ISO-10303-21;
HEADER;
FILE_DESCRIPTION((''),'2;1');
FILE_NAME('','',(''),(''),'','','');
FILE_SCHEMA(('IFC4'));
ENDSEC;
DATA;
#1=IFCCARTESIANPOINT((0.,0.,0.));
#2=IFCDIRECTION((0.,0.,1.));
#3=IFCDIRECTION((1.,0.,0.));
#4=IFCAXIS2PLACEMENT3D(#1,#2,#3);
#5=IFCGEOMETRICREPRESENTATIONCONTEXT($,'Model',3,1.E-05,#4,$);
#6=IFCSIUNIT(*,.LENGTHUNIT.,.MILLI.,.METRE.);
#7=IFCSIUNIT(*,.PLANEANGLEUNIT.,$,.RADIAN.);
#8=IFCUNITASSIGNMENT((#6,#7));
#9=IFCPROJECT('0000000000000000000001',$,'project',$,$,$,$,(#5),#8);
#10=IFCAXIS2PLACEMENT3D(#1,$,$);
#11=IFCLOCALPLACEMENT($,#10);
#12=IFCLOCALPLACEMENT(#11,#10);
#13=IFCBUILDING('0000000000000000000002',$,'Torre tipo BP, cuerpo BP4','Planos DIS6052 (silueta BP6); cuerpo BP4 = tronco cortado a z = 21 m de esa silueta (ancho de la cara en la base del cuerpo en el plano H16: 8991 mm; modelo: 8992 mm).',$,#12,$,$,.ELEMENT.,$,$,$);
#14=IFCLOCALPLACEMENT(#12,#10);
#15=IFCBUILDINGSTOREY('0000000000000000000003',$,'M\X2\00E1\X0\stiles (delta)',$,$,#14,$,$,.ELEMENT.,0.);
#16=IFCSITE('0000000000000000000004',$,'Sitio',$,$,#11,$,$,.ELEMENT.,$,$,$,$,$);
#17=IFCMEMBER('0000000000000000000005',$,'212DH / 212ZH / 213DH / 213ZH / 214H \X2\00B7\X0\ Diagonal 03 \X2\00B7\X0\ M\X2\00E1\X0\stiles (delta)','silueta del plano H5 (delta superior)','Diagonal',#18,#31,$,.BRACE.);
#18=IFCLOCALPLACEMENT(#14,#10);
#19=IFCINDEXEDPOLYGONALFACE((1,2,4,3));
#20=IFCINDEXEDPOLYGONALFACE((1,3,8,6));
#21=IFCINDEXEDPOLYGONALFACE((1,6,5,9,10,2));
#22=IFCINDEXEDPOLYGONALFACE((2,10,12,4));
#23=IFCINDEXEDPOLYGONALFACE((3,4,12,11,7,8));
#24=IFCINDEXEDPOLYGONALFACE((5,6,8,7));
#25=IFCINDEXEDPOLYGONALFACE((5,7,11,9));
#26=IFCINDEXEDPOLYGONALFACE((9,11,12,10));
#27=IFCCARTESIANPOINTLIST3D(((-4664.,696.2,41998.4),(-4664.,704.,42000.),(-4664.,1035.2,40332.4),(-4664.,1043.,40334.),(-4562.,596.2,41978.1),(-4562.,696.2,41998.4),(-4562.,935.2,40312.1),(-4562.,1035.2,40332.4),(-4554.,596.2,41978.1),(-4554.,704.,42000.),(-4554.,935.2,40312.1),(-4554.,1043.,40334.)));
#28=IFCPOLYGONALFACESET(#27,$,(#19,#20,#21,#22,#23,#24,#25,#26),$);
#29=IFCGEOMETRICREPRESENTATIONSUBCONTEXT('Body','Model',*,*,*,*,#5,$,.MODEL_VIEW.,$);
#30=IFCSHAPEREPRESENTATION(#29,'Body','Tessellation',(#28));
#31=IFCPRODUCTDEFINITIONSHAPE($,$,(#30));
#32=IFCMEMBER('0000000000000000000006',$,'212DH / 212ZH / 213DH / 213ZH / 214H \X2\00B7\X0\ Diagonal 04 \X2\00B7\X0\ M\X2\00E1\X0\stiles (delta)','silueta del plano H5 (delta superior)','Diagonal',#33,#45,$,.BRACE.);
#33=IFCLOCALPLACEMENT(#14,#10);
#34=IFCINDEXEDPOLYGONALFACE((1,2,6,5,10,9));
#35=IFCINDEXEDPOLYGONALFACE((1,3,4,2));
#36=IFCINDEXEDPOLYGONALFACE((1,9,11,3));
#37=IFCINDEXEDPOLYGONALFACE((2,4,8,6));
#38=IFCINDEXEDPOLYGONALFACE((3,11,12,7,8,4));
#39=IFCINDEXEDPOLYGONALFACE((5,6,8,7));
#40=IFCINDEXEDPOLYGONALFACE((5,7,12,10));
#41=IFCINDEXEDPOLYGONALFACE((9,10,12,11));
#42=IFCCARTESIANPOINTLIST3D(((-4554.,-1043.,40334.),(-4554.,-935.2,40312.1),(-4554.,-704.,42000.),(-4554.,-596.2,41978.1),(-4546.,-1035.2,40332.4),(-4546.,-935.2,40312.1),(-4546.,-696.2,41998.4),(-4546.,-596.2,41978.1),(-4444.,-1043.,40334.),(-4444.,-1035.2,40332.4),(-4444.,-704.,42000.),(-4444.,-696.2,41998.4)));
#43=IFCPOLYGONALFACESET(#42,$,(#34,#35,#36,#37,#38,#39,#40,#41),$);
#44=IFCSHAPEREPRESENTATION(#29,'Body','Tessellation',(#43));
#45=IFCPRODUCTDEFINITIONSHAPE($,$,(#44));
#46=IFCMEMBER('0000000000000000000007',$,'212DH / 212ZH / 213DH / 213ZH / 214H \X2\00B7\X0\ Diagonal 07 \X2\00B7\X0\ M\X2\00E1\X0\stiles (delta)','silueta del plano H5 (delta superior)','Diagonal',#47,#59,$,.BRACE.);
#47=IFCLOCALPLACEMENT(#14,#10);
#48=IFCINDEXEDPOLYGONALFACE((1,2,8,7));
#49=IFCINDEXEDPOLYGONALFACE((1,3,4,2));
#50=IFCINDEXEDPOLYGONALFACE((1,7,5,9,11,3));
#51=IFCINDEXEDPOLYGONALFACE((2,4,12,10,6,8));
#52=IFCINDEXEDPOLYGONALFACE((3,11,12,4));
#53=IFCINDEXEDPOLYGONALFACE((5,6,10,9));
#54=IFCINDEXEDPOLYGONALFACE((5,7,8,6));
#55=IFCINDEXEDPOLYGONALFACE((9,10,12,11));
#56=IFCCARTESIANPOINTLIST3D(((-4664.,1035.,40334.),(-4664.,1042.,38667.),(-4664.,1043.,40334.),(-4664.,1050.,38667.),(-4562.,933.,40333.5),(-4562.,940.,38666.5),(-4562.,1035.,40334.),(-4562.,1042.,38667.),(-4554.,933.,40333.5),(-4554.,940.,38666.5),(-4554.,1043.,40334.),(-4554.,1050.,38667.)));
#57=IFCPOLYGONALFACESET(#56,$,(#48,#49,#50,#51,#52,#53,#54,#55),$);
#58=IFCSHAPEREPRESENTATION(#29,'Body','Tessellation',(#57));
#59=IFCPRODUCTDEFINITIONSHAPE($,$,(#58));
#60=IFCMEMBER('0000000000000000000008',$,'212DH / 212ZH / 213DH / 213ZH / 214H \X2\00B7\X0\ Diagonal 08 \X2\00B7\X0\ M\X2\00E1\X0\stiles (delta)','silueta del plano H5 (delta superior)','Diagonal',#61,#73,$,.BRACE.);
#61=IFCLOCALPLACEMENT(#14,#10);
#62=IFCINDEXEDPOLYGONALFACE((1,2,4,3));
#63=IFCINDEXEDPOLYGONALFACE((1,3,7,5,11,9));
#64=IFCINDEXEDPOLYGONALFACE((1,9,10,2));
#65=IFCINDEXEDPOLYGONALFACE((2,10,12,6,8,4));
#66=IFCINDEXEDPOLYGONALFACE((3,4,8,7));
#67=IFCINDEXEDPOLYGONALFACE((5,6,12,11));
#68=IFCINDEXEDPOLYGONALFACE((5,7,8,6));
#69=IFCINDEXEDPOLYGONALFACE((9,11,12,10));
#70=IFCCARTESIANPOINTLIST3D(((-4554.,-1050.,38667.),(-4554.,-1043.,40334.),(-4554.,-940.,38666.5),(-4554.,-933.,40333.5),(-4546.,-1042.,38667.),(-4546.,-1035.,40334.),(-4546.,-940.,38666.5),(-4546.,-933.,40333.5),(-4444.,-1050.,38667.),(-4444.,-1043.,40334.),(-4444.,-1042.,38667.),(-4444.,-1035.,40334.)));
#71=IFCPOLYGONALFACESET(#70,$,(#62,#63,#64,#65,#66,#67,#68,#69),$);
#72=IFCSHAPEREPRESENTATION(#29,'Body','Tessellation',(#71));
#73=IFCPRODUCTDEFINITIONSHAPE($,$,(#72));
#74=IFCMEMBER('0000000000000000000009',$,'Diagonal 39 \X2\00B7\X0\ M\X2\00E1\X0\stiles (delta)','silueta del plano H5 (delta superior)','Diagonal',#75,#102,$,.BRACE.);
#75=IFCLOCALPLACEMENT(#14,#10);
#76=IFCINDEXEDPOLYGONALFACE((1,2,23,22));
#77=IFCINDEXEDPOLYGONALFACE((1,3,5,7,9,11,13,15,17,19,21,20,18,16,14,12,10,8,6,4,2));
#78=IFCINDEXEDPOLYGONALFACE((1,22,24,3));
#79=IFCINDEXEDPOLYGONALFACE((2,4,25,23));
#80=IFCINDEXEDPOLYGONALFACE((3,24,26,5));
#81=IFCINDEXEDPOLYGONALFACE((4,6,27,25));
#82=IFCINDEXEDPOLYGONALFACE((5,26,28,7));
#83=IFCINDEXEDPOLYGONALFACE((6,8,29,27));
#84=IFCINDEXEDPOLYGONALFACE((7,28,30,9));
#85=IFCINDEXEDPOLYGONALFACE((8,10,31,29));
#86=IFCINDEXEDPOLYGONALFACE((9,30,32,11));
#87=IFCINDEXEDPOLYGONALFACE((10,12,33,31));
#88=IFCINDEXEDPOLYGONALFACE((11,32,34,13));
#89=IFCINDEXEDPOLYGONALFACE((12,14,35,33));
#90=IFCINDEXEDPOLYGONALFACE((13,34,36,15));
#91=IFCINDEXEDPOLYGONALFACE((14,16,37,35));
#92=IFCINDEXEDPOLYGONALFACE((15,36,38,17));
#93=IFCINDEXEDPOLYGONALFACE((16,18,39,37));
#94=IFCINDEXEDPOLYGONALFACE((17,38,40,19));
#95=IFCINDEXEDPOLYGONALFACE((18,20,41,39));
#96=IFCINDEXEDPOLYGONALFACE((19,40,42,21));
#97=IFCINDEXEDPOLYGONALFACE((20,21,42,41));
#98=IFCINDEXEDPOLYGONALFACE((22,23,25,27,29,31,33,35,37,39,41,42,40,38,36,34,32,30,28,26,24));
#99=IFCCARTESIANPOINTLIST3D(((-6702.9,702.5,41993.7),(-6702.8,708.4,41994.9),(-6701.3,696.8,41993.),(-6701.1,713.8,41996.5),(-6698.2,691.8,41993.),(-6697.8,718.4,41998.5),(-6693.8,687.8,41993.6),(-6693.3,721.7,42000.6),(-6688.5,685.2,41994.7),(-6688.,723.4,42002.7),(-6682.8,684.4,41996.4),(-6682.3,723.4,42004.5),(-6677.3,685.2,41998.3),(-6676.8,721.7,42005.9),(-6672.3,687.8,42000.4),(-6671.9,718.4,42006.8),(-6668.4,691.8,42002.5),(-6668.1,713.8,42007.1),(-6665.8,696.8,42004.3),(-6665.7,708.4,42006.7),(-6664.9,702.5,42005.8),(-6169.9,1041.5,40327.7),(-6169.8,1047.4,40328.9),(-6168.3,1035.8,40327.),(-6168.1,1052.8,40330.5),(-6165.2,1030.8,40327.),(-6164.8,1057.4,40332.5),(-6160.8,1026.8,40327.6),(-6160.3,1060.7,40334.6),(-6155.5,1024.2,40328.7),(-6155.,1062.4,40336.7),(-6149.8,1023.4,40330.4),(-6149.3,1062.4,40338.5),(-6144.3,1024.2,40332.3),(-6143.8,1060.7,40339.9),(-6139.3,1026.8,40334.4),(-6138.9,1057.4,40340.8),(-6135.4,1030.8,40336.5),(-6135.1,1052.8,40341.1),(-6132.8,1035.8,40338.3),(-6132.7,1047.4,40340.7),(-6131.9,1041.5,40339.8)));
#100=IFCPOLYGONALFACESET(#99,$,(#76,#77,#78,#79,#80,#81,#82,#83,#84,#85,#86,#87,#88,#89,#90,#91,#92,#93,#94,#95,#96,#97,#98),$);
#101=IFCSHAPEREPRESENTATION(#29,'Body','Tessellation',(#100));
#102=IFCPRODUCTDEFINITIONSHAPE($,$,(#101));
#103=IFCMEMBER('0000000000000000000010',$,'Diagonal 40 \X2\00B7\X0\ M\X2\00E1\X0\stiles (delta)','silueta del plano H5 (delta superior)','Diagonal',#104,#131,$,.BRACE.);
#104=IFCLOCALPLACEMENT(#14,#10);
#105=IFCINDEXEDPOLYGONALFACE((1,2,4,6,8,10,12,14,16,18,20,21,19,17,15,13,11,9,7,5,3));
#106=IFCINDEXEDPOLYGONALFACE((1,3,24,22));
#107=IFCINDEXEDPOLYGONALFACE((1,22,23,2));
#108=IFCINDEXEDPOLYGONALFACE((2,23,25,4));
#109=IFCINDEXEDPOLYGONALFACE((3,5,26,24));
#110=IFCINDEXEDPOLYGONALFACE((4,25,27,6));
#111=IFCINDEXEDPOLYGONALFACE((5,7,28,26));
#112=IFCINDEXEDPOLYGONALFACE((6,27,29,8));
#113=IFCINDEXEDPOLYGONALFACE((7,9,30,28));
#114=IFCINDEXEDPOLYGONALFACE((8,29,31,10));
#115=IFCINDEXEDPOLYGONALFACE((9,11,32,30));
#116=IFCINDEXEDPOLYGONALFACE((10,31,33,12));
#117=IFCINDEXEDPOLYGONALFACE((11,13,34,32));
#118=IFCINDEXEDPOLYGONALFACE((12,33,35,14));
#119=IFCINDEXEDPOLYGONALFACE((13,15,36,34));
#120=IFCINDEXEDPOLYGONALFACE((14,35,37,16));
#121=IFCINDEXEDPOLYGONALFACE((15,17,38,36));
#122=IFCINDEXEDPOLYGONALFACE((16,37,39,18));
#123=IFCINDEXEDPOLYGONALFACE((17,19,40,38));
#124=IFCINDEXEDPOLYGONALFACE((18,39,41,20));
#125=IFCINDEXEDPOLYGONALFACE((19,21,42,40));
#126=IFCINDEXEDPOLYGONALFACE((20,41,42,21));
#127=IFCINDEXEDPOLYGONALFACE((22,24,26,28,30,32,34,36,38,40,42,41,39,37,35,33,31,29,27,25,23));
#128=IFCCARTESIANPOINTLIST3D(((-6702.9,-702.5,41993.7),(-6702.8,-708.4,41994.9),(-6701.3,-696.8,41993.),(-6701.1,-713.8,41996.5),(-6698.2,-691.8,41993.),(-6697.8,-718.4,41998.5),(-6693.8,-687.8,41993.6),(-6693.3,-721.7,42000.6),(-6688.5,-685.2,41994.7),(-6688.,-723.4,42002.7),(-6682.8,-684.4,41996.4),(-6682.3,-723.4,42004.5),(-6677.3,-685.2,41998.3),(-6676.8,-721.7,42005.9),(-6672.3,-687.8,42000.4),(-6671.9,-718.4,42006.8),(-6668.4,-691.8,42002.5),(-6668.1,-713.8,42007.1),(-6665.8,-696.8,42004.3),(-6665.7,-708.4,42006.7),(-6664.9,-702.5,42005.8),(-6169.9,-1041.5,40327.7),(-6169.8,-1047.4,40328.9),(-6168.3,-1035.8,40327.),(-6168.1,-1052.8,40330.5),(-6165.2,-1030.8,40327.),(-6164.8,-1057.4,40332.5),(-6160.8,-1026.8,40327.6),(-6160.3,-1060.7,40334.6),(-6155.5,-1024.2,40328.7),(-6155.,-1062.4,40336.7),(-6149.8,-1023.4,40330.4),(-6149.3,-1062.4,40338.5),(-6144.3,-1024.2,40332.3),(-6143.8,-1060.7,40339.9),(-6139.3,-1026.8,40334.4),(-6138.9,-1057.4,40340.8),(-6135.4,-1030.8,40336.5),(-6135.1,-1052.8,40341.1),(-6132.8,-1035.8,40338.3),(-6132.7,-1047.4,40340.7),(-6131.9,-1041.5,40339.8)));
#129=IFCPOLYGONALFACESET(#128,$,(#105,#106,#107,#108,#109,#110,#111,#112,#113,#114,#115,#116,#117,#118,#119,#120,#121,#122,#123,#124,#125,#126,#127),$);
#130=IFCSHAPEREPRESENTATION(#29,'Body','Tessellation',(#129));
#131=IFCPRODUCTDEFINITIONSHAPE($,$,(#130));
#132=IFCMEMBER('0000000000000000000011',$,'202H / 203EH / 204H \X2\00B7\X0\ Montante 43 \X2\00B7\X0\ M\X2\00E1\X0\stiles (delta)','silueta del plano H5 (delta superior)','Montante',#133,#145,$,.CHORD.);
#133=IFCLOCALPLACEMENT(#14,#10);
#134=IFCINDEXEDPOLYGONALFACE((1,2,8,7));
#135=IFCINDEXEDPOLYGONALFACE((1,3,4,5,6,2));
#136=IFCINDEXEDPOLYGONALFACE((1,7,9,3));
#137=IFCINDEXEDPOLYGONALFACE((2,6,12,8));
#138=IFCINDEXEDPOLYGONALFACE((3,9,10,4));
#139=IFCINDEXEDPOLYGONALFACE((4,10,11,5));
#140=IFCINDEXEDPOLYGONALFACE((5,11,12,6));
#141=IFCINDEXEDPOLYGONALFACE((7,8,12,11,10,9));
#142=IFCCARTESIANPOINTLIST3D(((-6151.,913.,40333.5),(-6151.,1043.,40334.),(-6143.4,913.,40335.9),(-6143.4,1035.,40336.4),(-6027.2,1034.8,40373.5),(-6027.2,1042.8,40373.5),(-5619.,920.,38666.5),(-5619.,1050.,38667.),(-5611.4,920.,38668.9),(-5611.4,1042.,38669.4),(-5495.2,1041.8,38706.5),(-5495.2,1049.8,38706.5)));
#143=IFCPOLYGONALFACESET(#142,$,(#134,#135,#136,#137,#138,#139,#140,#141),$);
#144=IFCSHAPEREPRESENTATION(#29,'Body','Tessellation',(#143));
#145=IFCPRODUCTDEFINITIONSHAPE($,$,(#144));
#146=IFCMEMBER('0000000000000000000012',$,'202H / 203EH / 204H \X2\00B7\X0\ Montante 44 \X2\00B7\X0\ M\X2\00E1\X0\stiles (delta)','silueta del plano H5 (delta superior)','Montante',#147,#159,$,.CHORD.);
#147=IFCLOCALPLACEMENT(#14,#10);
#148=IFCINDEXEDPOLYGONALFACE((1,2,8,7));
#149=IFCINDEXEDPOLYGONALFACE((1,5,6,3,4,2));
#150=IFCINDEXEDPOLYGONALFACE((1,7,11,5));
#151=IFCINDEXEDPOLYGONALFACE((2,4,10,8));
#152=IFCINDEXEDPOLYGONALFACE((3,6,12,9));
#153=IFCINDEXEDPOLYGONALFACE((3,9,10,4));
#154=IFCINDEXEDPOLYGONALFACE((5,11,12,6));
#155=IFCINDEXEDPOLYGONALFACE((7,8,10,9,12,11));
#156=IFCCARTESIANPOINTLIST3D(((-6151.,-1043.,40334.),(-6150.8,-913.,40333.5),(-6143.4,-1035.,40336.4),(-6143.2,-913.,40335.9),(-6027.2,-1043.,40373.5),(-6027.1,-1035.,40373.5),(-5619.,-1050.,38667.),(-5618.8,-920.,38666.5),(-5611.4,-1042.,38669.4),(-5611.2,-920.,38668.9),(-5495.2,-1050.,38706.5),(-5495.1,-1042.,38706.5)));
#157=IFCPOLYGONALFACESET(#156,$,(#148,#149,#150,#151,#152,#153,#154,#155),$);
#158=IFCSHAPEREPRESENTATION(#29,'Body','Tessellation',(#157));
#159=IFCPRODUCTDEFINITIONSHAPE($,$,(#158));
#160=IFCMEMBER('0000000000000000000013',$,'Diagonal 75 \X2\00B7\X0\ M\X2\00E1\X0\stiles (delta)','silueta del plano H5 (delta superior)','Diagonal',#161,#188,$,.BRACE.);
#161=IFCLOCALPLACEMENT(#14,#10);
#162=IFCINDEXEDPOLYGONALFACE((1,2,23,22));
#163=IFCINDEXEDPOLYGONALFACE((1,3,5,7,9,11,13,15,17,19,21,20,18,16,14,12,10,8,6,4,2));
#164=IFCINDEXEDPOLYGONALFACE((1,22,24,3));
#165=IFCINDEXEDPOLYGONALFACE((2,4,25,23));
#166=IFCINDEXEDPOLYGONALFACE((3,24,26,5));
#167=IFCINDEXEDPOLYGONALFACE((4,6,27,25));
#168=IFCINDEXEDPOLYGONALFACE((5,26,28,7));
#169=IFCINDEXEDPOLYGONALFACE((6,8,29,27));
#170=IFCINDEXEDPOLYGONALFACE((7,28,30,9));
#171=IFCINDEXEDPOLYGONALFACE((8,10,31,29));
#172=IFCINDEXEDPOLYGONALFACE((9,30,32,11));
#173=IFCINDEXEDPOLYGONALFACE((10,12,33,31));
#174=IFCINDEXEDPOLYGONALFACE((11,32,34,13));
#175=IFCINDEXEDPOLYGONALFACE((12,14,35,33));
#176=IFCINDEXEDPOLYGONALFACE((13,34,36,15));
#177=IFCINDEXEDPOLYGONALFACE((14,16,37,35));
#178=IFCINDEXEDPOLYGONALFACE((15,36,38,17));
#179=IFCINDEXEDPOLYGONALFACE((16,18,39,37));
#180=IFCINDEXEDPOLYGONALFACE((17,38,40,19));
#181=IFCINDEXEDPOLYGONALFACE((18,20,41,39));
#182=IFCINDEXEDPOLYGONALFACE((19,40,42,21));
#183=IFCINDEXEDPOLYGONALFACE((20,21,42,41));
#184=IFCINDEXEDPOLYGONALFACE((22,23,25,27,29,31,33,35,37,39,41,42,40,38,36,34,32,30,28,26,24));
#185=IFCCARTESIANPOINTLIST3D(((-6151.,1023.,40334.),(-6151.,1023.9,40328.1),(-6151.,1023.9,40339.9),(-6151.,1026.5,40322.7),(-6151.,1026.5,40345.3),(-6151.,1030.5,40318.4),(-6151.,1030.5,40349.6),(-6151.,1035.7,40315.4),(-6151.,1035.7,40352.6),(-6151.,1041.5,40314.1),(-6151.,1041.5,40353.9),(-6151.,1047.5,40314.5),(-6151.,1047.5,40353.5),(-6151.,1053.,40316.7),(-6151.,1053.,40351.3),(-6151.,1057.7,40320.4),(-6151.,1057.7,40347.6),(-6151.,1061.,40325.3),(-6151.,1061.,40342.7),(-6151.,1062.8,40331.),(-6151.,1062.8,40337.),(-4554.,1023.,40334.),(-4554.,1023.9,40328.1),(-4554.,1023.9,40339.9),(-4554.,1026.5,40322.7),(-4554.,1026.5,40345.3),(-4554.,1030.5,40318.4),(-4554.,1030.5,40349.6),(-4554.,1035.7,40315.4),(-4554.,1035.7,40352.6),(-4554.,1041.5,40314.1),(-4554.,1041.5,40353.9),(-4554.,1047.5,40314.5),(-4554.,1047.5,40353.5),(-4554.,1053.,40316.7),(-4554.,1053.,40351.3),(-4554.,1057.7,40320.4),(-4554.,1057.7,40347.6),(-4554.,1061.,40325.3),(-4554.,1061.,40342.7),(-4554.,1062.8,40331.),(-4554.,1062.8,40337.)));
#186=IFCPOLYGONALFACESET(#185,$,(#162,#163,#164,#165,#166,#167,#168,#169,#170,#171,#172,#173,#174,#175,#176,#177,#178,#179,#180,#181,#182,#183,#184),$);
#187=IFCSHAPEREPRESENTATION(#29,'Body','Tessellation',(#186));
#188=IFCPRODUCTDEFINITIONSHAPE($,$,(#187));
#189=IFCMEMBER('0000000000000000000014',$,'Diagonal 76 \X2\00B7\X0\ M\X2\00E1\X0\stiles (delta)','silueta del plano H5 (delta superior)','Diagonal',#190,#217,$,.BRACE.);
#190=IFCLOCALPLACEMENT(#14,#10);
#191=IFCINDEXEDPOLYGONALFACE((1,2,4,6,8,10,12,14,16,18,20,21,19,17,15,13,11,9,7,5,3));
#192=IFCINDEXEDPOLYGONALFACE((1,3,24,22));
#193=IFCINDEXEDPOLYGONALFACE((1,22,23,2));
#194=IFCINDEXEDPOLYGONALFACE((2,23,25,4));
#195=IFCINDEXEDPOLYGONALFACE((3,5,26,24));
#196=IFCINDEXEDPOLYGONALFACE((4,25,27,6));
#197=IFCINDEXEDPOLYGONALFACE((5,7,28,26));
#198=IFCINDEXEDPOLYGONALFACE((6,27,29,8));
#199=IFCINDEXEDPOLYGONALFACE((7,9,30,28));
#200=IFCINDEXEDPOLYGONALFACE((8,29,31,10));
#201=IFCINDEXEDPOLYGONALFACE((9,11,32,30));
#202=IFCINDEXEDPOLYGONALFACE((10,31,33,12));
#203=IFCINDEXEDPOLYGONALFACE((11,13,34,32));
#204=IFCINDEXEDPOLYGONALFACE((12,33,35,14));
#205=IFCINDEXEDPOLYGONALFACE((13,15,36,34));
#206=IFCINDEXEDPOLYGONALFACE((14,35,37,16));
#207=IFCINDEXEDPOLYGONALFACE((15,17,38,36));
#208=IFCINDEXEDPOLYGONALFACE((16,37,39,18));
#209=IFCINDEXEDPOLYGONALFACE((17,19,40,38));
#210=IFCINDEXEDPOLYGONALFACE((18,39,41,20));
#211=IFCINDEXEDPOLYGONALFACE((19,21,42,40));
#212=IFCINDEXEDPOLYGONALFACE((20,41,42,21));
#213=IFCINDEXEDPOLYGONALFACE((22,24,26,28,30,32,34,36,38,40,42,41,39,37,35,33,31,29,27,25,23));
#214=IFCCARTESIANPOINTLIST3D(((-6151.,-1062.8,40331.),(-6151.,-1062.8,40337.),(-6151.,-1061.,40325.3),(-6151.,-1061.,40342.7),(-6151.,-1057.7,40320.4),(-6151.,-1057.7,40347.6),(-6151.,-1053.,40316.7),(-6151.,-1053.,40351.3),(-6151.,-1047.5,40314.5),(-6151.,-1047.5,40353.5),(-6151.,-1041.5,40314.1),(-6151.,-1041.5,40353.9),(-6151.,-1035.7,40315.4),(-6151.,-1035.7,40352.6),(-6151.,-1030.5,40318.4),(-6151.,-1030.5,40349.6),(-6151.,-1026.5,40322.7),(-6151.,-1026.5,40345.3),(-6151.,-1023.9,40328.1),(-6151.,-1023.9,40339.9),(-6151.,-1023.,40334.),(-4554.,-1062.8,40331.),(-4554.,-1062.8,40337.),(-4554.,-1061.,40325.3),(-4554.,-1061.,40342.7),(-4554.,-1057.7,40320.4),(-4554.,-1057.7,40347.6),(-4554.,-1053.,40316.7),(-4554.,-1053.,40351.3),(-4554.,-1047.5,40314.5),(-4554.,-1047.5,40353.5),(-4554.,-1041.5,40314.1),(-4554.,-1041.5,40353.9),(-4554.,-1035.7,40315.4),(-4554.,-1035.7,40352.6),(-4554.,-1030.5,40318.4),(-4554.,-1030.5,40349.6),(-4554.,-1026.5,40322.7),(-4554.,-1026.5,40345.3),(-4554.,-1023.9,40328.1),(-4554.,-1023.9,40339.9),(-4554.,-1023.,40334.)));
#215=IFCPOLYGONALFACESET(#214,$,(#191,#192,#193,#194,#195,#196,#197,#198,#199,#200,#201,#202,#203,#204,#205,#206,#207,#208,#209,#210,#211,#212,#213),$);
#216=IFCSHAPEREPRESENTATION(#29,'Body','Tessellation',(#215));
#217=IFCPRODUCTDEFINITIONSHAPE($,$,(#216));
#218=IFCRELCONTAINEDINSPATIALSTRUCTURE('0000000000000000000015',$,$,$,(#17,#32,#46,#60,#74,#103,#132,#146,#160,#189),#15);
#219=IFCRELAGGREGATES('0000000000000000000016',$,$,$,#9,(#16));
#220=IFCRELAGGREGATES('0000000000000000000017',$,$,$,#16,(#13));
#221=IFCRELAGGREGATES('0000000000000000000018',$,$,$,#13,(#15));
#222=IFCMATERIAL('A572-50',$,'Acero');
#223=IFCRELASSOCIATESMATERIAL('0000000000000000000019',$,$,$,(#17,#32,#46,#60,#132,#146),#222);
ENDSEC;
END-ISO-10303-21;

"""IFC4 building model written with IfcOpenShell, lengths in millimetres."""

from ifc_helpers import new_model, si_unit, frame, frame_2d, origin, origin_with_axes, place, context, subcontext, project, spatial, circle, l_section, extrude, material, element, save


model = new_model("IFC4")

# Units and contexts
model_context = context("Model", 3, precision=1e-05, world=origin_with_axes())
body_context = subcontext(model_context, "Body", "Model", "MODEL_VIEW")
ifc_project = project(units=[si_unit("LENGTHUNIT", "METRE", prefix="MILLI"), si_unit("PLANEANGLEUNIT", "RADIAN")], contexts=[model_context])

# Site, building, storey
site_placement = place(None, origin())
site = spatial("IfcSite", under=ifc_project, at=site_placement, Name="Sitio", CompositionType="ELEMENT")
building_placement = place(site_placement, origin())
building = spatial("IfcBuilding", under=site, at=building_placement, Name="Torre tipo BP, cuerpo BP4", Description="Planos DIS6052 (silueta BP6); cuerpo BP4 = tronco cortado a z = 21 m de esa silueta (ancho de la cara en la base del cuerpo en el plano H16: 8991 mm; modelo: 8992 mm).", CompositionType="ELEMENT")
storey_placement = place(building_placement, origin())
storey = spatial("IfcBuildingStorey", under=building, at=storey_placement, Name="Mástiles (delta)", CompositionType="ELEMENT", Elevation=0.0)

# Members
ifc_material_1 = material(Name="A572-50", Category="Acero")
for number, where, z_axis, x_axis, name in (
    (1, (-4554.0, 704.0, 42000.0), (0.0, 0.199395, -0.979919), (0.0, -0.979919, -0.199395), "212DH / 212ZH / 213DH / 213ZH / 214H · Diagonal 03 · Mástiles (delta)"),
    (2, (-4554.0, -704.0, 42000.0), (0.0, -0.199395, -0.979919), (0.0, 0.979919, -0.199395), "212DH / 212ZH / 213DH / 213ZH / 214H · Diagonal 04 · Mástiles (delta)"),
):
    element("IfcMember", number, at=place(storey_placement, frame(where, z_axis=z_axis, x_axis=x_axis)), inside=storey, material=ifc_material_1, Name=name, Description="silueta del plano H5 (delta superior)", ObjectType="Diagonal", PredefinedType="BRACE", context=body_context, shape_type="SweptSolid", body=[
        extrude(l_section(Depth=110.0, Width=110.0, Thickness=8.0, at=frame_2d((55.0, 55.0))), None, (0.0, 0.0, 1.0), 1700.1),
    ])
for number, where, z_axis, x_axis, name in (
    (3, (-4554.0, 1043.0, 40334.0), (0.0, 0.004199, -0.999991), (0.0, -0.999991, -0.004199), "212DH / 212ZH / 213DH / 213ZH / 214H · Diagonal 07 · Mástiles (delta)"),
    (4, (-4554.0, -1043.0, 40334.0), (0.0, -0.004199, -0.999991), (0.0, 0.999991, -0.004199), "212DH / 212ZH / 213DH / 213ZH / 214H · Diagonal 08 · Mástiles (delta)"),
):
    element("IfcMember", number, at=place(storey_placement, frame(where, z_axis=z_axis, x_axis=x_axis)), inside=storey, material=ifc_material_1, Name=name, Description="silueta del plano H5 (delta superior)", ObjectType="Diagonal", PredefinedType="BRACE", context=body_context, shape_type="SweptSolid", body=[
        extrude(l_section(Depth=110.0, Width=110.0, Thickness=8.0, at=frame_2d((55.0, 55.0))), None, (0.0, 0.0, 1.0), 1667.0),
    ])
for number, where, z_axis, x_axis, name in (
    (5, (-6684.0, 704.0, 42000.0), (0.299147, 0.190264, -0.935046), (0.057976, -0.981733, -0.181216), "Diagonal 39 · Mástiles (delta)"),
    (6, (-6684.0, -704.0, 42000.0), (0.299147, -0.190264, -0.935046), (0.057976, 0.981733, -0.181216), "Diagonal 40 · Mástiles (delta)"),
):
    element("IfcMember", number, at=place(storey_placement, frame(where, z_axis=z_axis, x_axis=x_axis)), inside=storey, Name=name, Description="silueta del plano H5 (delta superior)", ObjectType="Diagonal", PredefinedType="BRACE", context=body_context, shape_type="SweptSolid", body=[
        extrude(circle(Radius=20.0), None, (0.0, 0.0, 1.0), 1781.7),
    ])
for number, where, z_axis, x_axis, name in (
    (7, (-6151.0, 1043.0, 40334.0), (0.304027, 0.004, -0.952655), (0.952664, -0.001277, 0.304024), "202H / 203EH / 204H · Montante 43 · Mástiles (delta)"),
    (8, (-6151.0, -1043.0, 40334.0), (0.304027, -0.004, -0.952655), (0.001216, 0.999992, -0.003811), "202H / 203EH / 204H · Montante 44 · Mástiles (delta)"),
):
    element("IfcMember", number, at=place(storey_placement, frame(where, z_axis=z_axis, x_axis=x_axis)), inside=storey, material=ifc_material_1, Name=name, Description="silueta del plano H5 (delta superior)", ObjectType="Montante", PredefinedType="CHORD", context=body_context, shape_type="SweptSolid", body=[
        extrude(l_section(Depth=130.0, Width=130.0, Thickness=8.0, at=frame_2d((65.0, 65.0))), None, (0.0, 0.0, 1.0), 1749.8),
    ])
for number, where, z_axis, x_axis, name in (
    (9, (-4554.0, 1043.0, 40334.0), (-1.0, 0.0, 0.0), (0.0, -1.0, 0.0), "Diagonal 75 · Mástiles (delta)"),
    (10, (-4554.0, -1043.0, 40334.0), (-1.0, 0.0, 0.0), (0.0, 1.0, 0.0), "Diagonal 76 · Mástiles (delta)"),
):
    element("IfcMember", number, at=place(storey_placement, frame(where, z_axis=z_axis, x_axis=x_axis)), inside=storey, Name=name, Description="silueta del plano H5 (delta superior)", ObjectType="Diagonal", PredefinedType="BRACE", context=body_context, shape_type="SweptSolid", body=[
        extrude(circle(Radius=20.0), None, (0.0, 0.0, 1.0), 1597.0),
    ])

save(model, "model.ifc")
